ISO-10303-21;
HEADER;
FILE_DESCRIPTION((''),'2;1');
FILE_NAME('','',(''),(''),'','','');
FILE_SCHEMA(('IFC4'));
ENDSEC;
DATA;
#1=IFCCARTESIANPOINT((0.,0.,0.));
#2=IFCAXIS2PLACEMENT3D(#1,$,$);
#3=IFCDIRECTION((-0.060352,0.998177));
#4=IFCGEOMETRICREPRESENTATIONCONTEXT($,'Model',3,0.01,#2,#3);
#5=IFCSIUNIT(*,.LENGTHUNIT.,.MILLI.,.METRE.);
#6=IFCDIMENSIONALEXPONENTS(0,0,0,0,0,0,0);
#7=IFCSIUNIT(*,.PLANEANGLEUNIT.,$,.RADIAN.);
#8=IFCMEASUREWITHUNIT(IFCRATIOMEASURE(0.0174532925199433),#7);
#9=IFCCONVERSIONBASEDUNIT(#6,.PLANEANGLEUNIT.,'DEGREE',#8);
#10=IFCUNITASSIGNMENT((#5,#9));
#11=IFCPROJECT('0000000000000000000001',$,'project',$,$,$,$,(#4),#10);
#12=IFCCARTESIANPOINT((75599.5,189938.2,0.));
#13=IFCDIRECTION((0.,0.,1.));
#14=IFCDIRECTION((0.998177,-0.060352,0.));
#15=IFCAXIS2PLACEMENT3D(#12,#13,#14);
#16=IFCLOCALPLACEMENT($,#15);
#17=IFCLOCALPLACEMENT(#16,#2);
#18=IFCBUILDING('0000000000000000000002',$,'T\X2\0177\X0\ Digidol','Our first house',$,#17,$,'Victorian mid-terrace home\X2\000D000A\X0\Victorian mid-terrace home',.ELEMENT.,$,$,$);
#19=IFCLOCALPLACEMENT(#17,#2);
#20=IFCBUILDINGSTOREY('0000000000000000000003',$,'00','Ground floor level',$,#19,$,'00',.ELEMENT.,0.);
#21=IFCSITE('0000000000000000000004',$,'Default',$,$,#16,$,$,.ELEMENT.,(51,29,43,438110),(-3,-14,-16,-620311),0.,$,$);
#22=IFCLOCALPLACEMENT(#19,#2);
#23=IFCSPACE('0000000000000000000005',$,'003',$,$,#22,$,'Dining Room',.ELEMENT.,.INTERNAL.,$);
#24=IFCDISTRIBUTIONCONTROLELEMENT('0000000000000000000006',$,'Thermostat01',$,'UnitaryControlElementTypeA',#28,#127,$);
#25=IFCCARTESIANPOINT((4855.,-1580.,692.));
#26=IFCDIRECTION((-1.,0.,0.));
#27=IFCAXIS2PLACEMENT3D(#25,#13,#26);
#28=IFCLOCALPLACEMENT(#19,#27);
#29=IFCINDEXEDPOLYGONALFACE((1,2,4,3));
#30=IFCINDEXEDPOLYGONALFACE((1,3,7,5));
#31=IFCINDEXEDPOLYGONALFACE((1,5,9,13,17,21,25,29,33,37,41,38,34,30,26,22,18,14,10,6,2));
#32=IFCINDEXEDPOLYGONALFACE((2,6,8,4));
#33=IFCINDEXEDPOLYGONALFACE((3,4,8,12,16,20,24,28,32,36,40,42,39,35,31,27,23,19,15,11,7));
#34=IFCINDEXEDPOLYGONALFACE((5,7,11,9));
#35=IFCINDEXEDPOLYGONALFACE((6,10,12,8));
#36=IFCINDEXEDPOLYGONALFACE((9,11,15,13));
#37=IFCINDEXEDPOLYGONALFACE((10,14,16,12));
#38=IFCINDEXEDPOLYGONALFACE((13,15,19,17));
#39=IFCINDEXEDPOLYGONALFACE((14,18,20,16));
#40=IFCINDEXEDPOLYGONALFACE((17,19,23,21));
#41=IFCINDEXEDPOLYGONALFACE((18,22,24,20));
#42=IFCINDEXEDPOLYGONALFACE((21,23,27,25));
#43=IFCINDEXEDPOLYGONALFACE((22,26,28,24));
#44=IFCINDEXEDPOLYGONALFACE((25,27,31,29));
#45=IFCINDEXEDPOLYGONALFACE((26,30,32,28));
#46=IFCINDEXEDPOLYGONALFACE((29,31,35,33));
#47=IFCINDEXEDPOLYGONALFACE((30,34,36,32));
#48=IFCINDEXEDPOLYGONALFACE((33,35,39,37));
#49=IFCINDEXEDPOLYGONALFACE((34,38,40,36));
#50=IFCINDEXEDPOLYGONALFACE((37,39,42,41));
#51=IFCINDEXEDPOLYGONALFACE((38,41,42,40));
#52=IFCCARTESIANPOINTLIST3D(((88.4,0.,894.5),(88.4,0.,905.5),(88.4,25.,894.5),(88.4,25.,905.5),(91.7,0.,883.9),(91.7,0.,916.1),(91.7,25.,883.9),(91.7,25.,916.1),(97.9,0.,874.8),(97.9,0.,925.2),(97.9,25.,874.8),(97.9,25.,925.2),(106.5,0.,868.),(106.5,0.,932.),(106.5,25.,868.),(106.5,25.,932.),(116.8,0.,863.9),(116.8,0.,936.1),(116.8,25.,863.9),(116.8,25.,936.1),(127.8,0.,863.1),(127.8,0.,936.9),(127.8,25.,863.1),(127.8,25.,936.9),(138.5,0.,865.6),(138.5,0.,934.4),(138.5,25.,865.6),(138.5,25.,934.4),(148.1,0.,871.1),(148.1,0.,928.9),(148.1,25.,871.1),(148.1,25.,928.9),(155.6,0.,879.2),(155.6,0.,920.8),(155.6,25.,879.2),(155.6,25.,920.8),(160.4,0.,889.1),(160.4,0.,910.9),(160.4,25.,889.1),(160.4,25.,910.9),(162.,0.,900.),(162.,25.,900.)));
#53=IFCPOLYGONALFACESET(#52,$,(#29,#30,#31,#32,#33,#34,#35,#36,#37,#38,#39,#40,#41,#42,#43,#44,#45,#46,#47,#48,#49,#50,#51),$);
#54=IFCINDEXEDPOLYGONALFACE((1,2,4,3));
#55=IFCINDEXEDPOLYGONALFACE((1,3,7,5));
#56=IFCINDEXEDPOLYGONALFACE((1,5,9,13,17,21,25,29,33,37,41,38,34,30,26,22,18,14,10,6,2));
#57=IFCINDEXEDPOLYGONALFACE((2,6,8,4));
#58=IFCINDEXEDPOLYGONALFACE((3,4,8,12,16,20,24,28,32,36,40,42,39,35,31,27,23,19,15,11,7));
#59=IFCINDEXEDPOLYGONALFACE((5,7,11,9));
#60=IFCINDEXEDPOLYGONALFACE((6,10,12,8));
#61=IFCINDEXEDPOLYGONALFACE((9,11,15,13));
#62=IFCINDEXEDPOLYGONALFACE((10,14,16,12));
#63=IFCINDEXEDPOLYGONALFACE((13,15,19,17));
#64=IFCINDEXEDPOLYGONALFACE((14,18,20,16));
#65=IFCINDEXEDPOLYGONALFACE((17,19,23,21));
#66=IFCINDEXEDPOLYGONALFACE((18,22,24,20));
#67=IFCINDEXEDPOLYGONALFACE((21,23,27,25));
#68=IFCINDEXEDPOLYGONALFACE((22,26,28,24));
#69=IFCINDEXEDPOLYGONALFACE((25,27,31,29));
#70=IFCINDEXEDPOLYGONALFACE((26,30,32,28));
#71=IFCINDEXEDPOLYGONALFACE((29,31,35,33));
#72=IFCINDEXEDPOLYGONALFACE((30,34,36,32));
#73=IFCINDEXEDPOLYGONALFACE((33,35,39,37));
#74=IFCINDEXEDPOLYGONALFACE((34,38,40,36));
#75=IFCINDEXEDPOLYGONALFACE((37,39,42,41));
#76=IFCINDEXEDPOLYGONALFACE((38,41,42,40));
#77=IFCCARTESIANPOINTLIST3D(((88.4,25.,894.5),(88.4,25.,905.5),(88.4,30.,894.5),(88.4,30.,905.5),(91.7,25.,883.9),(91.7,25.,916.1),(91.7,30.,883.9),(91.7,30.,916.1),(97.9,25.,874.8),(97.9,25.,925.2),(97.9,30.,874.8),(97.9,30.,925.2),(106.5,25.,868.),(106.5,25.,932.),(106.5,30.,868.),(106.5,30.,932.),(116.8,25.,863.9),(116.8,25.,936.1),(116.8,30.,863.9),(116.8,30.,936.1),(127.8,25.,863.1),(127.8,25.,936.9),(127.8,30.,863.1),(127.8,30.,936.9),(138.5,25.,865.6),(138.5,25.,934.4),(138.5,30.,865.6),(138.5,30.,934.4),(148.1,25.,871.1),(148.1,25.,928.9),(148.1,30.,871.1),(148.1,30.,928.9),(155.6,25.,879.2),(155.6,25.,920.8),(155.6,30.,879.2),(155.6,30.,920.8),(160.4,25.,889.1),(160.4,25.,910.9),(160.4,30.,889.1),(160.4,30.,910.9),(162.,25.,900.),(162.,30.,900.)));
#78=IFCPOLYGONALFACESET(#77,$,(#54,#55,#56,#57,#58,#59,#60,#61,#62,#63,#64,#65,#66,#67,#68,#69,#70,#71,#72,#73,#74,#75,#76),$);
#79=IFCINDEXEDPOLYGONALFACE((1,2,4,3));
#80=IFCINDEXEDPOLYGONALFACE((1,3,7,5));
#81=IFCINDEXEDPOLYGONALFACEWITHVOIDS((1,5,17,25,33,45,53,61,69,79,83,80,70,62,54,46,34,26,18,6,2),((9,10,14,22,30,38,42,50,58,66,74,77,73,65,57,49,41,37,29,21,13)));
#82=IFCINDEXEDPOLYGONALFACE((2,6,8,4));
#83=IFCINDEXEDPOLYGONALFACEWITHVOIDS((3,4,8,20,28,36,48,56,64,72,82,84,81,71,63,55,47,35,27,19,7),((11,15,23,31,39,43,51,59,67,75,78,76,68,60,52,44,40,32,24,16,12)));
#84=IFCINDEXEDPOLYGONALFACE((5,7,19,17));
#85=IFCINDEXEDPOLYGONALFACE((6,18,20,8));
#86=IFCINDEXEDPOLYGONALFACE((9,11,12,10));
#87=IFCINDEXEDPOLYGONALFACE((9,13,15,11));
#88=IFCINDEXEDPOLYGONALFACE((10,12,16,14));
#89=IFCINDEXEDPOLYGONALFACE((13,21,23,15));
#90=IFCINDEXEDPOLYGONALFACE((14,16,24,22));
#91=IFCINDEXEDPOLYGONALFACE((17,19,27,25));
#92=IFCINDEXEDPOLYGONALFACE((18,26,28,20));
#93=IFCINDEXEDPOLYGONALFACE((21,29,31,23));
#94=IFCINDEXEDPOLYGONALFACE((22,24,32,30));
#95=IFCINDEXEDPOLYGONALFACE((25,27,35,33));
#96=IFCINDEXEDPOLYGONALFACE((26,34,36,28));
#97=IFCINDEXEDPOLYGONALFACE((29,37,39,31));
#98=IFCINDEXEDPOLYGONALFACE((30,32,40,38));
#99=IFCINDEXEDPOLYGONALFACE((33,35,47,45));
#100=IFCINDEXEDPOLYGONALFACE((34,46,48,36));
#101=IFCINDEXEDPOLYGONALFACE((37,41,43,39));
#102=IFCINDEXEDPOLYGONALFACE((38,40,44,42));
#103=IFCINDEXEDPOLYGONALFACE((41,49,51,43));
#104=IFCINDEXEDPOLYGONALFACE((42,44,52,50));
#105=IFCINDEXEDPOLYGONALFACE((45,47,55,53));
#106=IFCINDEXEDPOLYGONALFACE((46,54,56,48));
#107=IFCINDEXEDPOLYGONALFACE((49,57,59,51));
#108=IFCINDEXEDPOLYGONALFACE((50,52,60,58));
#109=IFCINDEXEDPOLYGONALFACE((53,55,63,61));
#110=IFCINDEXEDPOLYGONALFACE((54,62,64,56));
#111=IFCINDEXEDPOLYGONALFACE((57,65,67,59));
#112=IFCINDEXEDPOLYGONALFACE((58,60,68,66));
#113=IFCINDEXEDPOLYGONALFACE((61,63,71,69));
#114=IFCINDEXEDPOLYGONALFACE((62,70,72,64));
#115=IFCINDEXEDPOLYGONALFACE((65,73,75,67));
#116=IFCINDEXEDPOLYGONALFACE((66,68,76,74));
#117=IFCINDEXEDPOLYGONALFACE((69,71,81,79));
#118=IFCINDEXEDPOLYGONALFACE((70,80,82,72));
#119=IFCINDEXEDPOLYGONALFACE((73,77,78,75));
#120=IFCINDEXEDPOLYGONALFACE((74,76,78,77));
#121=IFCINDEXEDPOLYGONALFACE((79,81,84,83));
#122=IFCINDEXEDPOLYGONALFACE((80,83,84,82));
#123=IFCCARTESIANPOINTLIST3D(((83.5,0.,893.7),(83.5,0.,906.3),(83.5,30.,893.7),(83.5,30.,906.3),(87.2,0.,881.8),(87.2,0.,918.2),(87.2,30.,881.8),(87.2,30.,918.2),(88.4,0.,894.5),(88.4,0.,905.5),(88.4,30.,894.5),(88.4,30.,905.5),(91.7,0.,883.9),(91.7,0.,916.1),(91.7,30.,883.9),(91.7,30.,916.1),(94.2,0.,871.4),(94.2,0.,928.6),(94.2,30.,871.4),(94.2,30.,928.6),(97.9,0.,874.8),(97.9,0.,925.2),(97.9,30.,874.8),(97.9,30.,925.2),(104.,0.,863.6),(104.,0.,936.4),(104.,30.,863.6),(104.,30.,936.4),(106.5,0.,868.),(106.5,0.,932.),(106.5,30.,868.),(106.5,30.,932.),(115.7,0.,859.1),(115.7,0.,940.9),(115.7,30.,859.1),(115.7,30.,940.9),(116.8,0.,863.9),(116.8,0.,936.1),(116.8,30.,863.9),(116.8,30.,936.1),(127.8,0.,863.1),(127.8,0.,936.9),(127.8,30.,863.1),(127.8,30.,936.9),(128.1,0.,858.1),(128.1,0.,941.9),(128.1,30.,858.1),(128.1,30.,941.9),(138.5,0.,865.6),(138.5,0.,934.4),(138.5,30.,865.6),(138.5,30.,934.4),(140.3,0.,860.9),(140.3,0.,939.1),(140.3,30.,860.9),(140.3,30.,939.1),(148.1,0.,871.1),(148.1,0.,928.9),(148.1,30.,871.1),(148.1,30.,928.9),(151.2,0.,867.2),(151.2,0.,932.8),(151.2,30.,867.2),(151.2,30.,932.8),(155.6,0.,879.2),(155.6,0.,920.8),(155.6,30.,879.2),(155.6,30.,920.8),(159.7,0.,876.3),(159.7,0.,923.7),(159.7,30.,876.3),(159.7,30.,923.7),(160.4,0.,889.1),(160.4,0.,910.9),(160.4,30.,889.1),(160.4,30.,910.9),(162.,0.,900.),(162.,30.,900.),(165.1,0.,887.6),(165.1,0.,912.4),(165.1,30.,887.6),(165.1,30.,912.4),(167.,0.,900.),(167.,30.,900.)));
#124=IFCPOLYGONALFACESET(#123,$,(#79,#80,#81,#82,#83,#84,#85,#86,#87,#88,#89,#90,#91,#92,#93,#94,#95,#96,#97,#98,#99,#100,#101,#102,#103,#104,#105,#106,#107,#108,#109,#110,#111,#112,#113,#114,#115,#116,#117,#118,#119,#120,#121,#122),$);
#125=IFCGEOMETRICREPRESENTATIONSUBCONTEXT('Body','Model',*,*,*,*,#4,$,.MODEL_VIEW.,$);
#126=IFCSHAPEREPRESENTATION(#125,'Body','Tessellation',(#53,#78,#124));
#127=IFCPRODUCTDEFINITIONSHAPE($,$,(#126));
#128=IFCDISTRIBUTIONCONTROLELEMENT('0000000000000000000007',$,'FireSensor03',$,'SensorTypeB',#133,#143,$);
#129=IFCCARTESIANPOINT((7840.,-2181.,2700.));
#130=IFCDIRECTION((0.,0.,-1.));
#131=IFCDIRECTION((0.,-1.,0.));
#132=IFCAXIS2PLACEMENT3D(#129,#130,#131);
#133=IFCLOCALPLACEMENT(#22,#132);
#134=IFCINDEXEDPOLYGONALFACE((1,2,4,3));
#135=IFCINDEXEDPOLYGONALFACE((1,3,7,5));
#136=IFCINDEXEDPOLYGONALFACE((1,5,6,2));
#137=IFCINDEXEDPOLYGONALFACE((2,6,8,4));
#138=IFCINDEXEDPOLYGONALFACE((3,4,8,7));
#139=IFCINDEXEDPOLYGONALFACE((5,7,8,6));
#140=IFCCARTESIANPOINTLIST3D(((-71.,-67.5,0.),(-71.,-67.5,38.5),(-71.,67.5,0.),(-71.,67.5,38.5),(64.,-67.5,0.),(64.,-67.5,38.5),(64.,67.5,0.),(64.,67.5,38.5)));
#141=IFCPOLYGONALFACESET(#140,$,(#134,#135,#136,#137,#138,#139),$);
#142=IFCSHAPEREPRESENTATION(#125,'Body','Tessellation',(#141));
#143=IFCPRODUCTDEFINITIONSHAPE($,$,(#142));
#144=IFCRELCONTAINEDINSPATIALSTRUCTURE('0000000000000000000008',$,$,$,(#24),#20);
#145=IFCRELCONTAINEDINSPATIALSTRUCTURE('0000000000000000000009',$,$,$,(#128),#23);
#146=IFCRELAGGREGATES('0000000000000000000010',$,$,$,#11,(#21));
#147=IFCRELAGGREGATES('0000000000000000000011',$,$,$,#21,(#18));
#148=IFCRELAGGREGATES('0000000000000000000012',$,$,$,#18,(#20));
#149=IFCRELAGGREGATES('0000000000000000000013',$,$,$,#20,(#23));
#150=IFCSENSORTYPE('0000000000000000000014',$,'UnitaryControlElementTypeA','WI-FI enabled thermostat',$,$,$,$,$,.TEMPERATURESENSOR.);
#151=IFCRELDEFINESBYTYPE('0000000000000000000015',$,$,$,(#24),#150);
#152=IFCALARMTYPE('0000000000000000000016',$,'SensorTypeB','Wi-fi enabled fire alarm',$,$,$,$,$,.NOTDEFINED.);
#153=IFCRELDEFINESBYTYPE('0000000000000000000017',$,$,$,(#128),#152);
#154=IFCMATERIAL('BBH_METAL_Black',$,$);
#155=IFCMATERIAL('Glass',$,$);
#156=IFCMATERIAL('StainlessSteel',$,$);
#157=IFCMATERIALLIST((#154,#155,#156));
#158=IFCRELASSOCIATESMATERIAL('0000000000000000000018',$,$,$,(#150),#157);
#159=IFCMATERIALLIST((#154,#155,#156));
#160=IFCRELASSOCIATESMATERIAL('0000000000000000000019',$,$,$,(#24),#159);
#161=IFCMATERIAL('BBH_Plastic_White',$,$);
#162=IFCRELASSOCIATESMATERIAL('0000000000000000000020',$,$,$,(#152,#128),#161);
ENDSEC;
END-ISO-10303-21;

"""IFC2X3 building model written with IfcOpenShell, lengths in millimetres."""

from ifc_helpers import new_model, entity, si_unit, converted_unit, direction, frame, frame_2d, origin, origin_2d_with_axis, place, context, subcontext, project, spatial, rectangle, circle, hollow_circle, extrude, source, transform, mapped, material, material_list, type_object, type_shapes, element, save


model = new_model("IFC2X3")

# Units and contexts
model_context = context("Model", 3, precision=0.01, world=origin(), true_north=direction((-0.060352, 0.998177)))
body_context = subcontext(model_context, "Body", "Model", "MODEL_VIEW")
ifc_project = project(units=[si_unit("LENGTHUNIT", "METRE", prefix="MILLI"), converted_unit("PLANEANGLEUNIT", "DEGREE", entity("IfcRatioMeasure", 0.0174532925199433), si_unit("PLANEANGLEUNIT", "RADIAN"), dimensions=[0, 0, 0, 0, 0, 0, 0])], contexts=[model_context])

# Site, building, storey
site_placement = place(None, frame((75599.5, 189938.2, 0.0), z_axis=(0.0, 0.0, 1.0), x_axis=(0.998177, -0.060352, 0.0)))
site = spatial("IfcSite", under=ifc_project, at=site_placement, Name="Default", CompositionType="ELEMENT", RefLatitude=(51, 29, 43, 438110), RefLongitude=(-3, -14, -16, -620311), RefElevation=0.0)
building_placement = place(site_placement, origin())
building = spatial("IfcBuilding", under=site, at=building_placement, Name="Tŷ Digidol", Description="Our first house", LongName="Victorian mid-terrace home\r\nVictorian mid-terrace home", CompositionType="ELEMENT")
storey_placement = place(building_placement, origin())
storey = spatial("IfcBuildingStorey", under=building, at=storey_placement, Name="00", Description="Ground floor level", LongName="00", CompositionType="ELEMENT", Elevation=0.0)

# Distribution control element
ifc_material_1 = material(Name="BBH_METAL_Black")
ifc_material_2 = material(Name="Glass")
ifc_material_3 = material(Name="StainlessSteel")
ifc_material_list_1 = material_list([ifc_material_1, ifc_material_2, ifc_material_3])
ifc_material_list_2 = material_list([ifc_material_1, ifc_material_2, ifc_material_3])
sensor_type_1 = type_object("IfcSensorType", Name="UnitaryControlElementTypeA", Description="WI-FI enabled thermostat", PredefinedType="TEMPERATURESENSOR", material=ifc_material_list_2)
shared_shape_1 = source(origin(), body_context, "Body", "SweptSolid", [
    extrude(circle(Radius=37.0, at=frame_2d((0.0, 0.0), x_axis=(1.0, 0.0))), frame((125.0, 0.0, 900.0), z_axis=(0.0, 1.0, 0.0), x_axis=(1.0, 0.0, 0.0)), (0.0, 0.0, 1.0), 25.0),
    extrude(circle(Radius=37.0, at=frame_2d((0.0, 0.0), x_axis=(1.0, 0.0))), frame((125.0, 25.0, 900.0), z_axis=(0.0, 1.0, 0.0), x_axis=(1.0, 0.0, 0.0)), (0.0, 0.0, 1.0), 5.0),
    extrude(hollow_circle(Radius=42.0, WallThickness=5.0, at=frame_2d((0.0, 0.0), x_axis=(1.0, 0.0))), frame((125.0, 0.0, 900.0), z_axis=(0.0, 1.0, 0.0), x_axis=(1.0, 0.0, 0.0)), (0.0, 0.0, 1.0), 30.0),
])
type_shapes(sensor_type_1, [shared_shape_1])
distribution_control_element_1_placement = place(storey_placement, frame((4855.0, -1580.0, 692.0), z_axis=(0.0, 0.0, 1.0), x_axis=(-1.0, 0.0, 0.0)))
element("IfcDistributionControlElement", 1, at=distribution_control_element_1_placement, inside=storey, type_object=sensor_type_1, material=ifc_material_list_1, Name="Thermostat01", ObjectType="UnitaryControlElementTypeA", context=body_context, shape_type="MappedRepresentation", body=[
    mapped(shared_shape_1, transform((0.0, 0.0, 0.0), scale=1.0)),
])

# Shared definitions
ifc_material_4 = material(Name="BBH_Plastic_White")

# Shared definitions
space_1_placement = place(storey_placement, origin())
space_1 = spatial("IfcSpace", under=storey, at=space_1_placement, Name="003", LongName="Dining Room", CompositionType="ELEMENT", InteriorOrExteriorSpace="INTERNAL")

# Distribution control element
alarm_type_1 = type_object("IfcAlarmType", Name="SensorTypeB", Description="Wi-fi enabled fire alarm", PredefinedType="NOTDEFINED", material=ifc_material_4)
shared_shape_2 = source(origin(), body_context, "Body", "SweptSolid", [
    extrude(rectangle(XDim=135.0, YDim=135.0, at=origin_2d_with_axis()), frame((-3.5, 0.0, 0.0), z_axis=(0.0, 0.0, 1.0), x_axis=(-1.0, 0.0, 0.0)), (0.0, 0.0, 1.0), 38.5),
])
type_shapes(alarm_type_1, [shared_shape_2])
distribution_control_element_2_placement = place(space_1_placement, frame((7840.0, -2181.0, 2700.0), z_axis=(0.0, 0.0, -1.0), x_axis=(0.0, -1.0, 0.0)))
element("IfcDistributionControlElement", 2, at=distribution_control_element_2_placement, inside=space_1, type_object=alarm_type_1, material=ifc_material_4, Name="FireSensor03", ObjectType="SensorTypeB", context=body_context, shape_type="MappedRepresentation", body=[
    mapped(shared_shape_2, transform((0.0, 0.0, 0.0), scale=1.0)),
])

save(model, "model.ifc")
